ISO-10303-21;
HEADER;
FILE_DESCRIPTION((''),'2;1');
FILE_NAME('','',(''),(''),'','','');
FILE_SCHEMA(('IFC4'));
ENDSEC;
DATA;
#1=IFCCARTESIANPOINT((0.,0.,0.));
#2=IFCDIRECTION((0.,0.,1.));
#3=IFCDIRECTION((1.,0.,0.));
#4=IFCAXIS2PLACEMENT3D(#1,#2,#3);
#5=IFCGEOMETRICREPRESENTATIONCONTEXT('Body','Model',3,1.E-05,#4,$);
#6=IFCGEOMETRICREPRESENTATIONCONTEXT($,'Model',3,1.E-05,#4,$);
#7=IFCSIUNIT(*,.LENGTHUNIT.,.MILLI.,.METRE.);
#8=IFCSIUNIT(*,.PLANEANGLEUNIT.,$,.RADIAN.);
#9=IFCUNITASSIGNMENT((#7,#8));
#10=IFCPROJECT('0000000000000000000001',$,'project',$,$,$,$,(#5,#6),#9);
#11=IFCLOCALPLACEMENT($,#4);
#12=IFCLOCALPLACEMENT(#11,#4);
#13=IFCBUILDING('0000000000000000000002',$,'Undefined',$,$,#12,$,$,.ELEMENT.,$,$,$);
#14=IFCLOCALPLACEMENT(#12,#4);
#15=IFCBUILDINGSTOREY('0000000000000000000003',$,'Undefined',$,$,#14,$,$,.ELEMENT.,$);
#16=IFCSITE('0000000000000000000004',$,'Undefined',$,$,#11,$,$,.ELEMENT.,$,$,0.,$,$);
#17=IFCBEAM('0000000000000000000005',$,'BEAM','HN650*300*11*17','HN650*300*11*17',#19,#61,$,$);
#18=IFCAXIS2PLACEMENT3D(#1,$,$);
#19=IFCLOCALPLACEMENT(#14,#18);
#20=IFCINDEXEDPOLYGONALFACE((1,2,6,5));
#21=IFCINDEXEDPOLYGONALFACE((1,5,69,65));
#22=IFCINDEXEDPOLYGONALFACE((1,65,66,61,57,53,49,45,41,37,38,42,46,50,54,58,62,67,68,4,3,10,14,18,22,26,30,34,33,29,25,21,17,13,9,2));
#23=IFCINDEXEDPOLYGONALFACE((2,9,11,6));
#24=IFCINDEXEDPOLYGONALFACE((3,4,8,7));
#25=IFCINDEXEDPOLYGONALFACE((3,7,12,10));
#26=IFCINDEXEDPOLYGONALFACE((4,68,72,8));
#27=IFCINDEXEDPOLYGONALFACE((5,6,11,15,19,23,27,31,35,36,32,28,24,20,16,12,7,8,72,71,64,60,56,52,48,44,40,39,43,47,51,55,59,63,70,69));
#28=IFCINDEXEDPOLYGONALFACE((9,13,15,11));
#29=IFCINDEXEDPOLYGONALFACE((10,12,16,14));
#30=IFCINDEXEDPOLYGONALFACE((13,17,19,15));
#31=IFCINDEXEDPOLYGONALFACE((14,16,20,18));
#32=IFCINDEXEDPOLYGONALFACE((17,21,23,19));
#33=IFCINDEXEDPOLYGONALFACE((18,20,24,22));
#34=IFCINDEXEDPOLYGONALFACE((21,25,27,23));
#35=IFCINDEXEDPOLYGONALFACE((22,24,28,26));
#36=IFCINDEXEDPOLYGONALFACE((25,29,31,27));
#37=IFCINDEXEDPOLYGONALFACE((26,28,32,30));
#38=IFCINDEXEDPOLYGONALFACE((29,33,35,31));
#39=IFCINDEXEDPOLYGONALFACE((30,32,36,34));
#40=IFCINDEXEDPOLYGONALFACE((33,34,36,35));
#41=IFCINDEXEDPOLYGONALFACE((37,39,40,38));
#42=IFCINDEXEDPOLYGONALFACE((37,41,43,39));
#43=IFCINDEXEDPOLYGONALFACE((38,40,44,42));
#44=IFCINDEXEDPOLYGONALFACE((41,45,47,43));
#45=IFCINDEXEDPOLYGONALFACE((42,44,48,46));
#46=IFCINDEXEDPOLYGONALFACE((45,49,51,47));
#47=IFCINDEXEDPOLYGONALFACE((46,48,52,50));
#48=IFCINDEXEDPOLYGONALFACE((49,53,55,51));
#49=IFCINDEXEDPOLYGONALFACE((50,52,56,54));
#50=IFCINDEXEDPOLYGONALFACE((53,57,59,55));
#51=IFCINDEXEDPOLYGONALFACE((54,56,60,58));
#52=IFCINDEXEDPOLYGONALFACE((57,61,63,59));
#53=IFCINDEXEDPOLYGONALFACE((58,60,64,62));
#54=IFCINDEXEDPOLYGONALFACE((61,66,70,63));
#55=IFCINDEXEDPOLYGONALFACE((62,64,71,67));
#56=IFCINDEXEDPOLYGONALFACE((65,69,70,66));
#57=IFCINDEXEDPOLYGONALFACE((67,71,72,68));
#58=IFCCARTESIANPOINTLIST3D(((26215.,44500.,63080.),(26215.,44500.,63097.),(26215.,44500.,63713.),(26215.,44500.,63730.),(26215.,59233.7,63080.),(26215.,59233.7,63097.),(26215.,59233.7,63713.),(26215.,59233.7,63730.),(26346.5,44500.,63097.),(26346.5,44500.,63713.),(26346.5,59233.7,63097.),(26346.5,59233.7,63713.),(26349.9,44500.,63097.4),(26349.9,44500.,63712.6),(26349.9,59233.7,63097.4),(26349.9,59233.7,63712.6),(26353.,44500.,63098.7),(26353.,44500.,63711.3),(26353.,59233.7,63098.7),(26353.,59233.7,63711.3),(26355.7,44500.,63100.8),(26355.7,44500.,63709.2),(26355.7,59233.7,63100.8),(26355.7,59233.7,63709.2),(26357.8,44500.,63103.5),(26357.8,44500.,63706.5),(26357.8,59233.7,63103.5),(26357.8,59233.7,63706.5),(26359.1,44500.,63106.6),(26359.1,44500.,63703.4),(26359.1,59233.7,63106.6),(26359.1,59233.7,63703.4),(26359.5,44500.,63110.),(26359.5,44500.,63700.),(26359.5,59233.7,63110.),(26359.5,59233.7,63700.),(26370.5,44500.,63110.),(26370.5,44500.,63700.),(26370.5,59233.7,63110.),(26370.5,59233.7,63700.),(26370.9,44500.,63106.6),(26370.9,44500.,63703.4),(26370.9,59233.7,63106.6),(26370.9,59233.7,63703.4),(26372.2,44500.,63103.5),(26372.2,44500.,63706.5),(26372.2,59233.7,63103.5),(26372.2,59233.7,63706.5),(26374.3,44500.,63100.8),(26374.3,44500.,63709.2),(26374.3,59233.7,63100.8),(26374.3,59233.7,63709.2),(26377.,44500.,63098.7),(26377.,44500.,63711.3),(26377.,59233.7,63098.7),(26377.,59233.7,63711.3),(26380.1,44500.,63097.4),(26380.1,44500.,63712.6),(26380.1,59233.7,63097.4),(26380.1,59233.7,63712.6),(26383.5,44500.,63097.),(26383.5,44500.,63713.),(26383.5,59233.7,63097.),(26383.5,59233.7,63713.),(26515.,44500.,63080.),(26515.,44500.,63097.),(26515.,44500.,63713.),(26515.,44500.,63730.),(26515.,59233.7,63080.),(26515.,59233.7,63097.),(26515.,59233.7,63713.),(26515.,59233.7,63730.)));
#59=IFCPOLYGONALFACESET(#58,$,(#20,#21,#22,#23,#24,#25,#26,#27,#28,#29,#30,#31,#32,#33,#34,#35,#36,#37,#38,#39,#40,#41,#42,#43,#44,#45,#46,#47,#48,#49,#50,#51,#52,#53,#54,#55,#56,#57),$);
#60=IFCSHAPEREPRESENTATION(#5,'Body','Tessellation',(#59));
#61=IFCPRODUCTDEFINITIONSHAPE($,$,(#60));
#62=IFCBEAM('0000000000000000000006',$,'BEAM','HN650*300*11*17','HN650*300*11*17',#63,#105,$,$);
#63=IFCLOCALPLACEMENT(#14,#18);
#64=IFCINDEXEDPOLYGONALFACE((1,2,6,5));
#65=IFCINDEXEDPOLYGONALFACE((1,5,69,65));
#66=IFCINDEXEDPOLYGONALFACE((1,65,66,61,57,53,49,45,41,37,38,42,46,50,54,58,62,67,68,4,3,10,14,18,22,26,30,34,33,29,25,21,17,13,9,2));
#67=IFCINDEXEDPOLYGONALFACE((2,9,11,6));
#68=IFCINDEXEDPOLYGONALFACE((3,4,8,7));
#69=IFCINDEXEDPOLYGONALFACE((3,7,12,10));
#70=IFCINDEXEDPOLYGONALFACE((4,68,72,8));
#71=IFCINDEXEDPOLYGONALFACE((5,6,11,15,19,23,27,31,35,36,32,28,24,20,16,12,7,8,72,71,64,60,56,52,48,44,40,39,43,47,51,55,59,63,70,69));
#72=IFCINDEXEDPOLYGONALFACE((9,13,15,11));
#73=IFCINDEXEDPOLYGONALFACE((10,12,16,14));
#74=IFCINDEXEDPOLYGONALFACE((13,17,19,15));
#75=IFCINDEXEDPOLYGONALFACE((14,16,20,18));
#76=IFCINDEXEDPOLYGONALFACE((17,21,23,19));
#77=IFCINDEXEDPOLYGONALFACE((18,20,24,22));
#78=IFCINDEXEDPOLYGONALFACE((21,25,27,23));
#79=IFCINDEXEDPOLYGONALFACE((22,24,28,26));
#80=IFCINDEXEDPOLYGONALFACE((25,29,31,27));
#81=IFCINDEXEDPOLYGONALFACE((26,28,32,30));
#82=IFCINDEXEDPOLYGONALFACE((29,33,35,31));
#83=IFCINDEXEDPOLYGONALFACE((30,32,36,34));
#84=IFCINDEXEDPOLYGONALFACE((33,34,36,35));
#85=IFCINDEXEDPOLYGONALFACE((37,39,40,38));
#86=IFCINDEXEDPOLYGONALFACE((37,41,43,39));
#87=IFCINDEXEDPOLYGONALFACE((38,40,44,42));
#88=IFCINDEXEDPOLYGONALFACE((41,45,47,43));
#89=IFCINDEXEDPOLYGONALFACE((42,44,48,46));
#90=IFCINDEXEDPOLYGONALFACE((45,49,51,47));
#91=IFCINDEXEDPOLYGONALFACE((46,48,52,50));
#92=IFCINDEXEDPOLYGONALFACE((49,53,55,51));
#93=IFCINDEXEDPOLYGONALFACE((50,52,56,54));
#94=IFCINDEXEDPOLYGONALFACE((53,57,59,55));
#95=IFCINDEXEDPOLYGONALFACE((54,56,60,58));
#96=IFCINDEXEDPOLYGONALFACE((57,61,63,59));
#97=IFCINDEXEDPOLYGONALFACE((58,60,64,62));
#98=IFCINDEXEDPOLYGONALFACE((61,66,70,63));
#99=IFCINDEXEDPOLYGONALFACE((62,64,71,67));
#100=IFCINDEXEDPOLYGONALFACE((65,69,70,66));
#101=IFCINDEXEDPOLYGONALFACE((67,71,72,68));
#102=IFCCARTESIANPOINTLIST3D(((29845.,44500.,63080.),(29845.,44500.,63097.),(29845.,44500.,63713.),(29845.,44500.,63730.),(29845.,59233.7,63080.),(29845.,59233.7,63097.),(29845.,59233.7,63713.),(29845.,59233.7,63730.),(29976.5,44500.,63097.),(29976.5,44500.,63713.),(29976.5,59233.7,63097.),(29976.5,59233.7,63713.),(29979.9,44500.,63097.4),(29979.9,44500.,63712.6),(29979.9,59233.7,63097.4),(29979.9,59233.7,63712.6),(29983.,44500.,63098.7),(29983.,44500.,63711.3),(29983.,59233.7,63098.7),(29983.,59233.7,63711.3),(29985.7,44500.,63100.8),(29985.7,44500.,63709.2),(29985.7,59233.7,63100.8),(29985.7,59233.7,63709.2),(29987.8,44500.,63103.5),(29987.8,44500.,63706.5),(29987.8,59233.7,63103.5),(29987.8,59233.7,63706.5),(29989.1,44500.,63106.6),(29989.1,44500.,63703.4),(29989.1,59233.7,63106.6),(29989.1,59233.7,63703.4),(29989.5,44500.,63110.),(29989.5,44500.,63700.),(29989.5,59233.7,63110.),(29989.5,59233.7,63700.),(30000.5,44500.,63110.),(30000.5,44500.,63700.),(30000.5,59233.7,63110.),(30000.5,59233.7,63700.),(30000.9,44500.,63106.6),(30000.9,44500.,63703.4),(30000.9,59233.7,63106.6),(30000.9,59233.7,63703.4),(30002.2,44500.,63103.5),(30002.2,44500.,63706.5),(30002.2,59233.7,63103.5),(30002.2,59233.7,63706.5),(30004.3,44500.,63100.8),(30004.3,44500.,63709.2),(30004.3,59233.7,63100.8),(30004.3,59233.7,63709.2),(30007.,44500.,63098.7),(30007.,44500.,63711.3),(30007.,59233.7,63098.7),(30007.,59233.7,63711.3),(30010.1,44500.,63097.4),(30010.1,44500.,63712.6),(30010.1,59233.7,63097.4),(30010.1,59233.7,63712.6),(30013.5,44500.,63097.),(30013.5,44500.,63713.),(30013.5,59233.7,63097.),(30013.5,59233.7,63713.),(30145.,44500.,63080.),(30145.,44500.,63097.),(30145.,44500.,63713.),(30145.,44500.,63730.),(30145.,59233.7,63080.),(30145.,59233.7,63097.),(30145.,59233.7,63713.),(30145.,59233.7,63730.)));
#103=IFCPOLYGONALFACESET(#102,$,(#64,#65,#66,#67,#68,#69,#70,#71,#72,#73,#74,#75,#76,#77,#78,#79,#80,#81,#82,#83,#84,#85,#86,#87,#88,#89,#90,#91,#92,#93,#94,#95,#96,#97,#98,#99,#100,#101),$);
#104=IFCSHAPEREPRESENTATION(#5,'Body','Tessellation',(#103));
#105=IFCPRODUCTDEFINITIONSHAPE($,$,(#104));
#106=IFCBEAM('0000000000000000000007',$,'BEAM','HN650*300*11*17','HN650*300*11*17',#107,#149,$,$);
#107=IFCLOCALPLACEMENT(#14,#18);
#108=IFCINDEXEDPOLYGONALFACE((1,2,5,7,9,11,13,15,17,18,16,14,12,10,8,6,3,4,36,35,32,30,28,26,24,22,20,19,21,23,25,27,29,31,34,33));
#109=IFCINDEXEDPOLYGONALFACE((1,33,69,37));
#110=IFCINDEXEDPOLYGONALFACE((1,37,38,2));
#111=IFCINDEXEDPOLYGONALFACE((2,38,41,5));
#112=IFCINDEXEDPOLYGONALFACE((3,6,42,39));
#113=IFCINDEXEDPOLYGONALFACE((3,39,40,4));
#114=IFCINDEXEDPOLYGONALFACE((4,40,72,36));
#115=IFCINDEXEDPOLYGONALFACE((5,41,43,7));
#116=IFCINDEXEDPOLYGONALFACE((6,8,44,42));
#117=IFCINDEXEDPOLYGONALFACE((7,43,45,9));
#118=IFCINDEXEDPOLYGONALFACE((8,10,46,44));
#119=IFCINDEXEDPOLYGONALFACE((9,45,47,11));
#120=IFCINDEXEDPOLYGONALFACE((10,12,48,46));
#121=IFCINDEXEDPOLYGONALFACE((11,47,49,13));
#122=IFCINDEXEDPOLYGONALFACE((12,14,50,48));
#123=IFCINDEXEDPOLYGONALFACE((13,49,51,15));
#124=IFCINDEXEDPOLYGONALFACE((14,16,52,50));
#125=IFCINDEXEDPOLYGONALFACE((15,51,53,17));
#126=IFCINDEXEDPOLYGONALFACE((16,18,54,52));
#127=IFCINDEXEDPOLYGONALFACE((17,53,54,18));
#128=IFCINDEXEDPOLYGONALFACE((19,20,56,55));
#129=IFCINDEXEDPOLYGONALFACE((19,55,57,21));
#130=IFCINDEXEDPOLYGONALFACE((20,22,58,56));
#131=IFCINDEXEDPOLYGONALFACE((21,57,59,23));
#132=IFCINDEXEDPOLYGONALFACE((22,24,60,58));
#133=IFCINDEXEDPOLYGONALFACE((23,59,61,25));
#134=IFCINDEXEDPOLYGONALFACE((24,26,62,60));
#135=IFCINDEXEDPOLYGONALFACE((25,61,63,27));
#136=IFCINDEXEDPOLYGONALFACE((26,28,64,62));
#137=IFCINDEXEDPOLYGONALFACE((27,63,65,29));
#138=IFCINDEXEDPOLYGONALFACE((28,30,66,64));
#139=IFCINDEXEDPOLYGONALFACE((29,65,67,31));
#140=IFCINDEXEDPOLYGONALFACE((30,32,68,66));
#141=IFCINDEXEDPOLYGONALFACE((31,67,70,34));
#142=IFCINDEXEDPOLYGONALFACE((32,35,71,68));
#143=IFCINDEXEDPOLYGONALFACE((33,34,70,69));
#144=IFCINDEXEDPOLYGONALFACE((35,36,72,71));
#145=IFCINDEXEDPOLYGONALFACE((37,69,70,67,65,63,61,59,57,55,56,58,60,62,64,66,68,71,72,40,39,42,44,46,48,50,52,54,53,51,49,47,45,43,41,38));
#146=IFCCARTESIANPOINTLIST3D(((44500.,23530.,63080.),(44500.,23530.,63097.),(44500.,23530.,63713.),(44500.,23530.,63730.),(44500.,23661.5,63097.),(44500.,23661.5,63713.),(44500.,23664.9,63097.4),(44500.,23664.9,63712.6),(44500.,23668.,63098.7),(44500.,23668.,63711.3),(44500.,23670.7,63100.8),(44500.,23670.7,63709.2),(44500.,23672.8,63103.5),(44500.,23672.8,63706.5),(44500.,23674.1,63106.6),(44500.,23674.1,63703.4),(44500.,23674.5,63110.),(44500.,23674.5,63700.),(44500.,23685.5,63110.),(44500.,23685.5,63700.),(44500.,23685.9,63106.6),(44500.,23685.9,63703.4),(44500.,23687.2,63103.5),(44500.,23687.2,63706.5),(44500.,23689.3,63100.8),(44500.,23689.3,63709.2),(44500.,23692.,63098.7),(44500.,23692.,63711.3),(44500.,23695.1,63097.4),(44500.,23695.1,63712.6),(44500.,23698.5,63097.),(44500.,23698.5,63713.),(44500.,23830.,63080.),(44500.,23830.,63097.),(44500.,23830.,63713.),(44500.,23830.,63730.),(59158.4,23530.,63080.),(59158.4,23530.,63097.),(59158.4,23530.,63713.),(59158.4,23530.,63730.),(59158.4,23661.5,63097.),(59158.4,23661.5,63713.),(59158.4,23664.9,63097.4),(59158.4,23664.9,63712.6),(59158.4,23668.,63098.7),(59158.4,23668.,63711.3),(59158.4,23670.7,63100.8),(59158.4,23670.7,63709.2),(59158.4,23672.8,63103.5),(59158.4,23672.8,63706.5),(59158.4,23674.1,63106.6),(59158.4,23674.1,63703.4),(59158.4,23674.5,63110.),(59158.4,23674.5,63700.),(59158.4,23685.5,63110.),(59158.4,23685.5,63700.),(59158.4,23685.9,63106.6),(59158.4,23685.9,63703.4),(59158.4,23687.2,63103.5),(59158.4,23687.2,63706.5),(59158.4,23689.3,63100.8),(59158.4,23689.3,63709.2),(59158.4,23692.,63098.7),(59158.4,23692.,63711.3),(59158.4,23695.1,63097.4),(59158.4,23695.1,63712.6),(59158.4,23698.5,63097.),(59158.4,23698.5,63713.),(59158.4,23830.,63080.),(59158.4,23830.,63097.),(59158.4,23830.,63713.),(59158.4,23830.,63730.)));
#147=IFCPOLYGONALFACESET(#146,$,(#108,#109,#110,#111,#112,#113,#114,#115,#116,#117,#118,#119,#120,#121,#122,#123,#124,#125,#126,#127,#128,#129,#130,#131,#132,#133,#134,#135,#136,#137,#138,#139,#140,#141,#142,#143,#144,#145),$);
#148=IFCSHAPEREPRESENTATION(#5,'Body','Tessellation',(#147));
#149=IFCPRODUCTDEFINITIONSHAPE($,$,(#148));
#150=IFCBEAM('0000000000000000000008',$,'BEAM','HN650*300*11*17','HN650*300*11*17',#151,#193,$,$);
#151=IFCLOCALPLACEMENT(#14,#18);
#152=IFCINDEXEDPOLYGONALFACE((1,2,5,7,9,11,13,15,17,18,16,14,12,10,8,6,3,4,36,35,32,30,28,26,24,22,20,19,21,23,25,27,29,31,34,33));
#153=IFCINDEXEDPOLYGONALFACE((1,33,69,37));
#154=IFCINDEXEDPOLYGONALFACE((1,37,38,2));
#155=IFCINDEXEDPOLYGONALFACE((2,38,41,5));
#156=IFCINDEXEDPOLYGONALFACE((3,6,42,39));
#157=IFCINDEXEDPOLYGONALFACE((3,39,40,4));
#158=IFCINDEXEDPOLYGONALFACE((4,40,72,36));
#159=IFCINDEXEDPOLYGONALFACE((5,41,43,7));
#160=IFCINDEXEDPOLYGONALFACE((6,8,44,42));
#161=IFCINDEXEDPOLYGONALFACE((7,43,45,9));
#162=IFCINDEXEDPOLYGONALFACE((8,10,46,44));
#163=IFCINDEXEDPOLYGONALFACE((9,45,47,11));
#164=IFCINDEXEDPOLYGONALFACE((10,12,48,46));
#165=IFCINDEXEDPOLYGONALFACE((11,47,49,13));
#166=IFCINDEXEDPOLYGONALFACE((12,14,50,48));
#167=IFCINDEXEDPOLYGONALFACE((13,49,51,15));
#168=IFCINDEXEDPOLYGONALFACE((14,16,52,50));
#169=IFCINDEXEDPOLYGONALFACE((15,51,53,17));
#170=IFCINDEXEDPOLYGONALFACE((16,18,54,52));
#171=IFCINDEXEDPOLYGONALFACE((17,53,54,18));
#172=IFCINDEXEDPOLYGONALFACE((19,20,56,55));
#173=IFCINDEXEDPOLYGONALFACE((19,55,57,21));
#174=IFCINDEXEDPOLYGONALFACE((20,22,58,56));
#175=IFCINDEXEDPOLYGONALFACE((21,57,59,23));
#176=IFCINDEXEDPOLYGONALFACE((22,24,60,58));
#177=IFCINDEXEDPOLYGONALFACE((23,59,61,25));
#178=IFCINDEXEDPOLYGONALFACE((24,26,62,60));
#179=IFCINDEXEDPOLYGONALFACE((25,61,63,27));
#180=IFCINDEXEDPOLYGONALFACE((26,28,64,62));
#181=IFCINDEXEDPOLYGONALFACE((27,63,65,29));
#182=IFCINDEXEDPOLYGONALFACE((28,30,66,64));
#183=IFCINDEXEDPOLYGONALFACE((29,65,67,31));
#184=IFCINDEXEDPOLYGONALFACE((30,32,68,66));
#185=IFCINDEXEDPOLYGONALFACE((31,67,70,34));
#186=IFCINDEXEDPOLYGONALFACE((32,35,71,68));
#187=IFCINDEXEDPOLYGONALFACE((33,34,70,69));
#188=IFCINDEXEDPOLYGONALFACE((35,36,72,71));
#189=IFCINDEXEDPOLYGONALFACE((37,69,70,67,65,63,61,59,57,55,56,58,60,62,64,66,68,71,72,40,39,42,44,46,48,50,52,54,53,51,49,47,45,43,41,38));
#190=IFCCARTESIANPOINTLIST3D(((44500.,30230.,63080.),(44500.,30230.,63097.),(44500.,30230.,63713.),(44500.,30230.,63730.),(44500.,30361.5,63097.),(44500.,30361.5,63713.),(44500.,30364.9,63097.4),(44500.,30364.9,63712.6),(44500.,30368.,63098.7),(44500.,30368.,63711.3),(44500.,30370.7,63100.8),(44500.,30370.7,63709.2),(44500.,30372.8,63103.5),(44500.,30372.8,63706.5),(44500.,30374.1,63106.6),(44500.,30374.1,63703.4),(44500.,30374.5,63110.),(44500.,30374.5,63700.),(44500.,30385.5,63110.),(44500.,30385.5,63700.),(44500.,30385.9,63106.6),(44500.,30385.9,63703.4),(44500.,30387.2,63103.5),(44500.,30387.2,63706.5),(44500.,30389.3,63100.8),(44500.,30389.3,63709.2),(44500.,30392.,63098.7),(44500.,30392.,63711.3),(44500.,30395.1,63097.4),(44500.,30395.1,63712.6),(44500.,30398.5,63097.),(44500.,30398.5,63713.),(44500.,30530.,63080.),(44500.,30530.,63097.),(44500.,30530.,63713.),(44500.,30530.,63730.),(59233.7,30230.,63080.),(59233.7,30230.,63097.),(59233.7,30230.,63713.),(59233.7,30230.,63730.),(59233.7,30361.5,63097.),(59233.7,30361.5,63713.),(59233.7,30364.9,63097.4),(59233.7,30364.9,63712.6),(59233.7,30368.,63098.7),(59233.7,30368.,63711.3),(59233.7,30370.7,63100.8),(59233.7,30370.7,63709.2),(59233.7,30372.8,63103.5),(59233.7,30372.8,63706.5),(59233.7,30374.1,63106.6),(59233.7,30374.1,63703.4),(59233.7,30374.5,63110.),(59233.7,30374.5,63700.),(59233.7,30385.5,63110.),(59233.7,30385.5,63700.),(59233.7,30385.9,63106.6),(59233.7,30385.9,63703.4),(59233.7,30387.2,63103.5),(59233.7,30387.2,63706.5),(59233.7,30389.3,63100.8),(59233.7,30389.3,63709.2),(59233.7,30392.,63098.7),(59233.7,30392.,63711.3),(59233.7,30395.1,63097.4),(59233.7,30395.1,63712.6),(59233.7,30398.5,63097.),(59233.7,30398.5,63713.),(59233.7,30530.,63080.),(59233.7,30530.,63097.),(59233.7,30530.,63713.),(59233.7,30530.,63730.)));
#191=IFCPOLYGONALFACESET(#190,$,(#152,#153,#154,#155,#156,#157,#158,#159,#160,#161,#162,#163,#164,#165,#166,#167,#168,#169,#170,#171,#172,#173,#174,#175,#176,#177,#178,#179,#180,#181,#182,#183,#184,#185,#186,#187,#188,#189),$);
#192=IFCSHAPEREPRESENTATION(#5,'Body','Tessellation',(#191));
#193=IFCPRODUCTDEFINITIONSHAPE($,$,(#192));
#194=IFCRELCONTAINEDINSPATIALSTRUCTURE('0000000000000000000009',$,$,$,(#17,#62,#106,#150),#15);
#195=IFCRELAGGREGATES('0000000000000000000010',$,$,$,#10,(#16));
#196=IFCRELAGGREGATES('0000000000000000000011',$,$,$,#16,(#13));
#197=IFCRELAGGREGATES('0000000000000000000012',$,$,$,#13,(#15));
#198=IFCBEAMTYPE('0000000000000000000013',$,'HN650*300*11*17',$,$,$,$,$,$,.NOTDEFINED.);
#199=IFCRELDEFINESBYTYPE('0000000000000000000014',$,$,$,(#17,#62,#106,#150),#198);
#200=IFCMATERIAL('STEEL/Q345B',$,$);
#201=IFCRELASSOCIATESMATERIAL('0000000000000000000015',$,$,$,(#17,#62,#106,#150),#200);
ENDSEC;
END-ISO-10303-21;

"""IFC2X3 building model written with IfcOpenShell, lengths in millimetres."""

from ifc_helpers import new_model, si_unit, frame, origin_with_axes, origin_2d_with_axis, place, context, project, spatial, i_section, extrude, material, type_object, element, save


model = new_model("IFC2X3")

# Units and contexts
model_context_1 = context("Model", 3, precision=1e-05, world=origin_with_axes(), identifier="Body")
model_context_2 = context("Model", 3, precision=1e-05, world=origin_with_axes())
ifc_project = project(units=[si_unit("LENGTHUNIT", "METRE", prefix="MILLI"), si_unit("PLANEANGLEUNIT", "RADIAN")], contexts=[model_context_1, model_context_2])

# Site, building, storey
site_placement = place(None, origin_with_axes())
site = spatial("IfcSite", under=ifc_project, at=site_placement, Name="Undefined", CompositionType="ELEMENT", RefElevation=0.0)
building_placement = place(site_placement, origin_with_axes())
building = spatial("IfcBuilding", under=site, at=building_placement, Name="Undefined", CompositionType="ELEMENT")
storey_placement = place(building_placement, origin_with_axes())
storey = spatial("IfcBuildingStorey", under=building, at=storey_placement, Name="Undefined", CompositionType="ELEMENT")

# Beams
ifc_material_1 = material(Name="STEEL/Q345B")
beam_type_1 = type_object("IfcBeamType", Name="HN650*300*11*17", PredefinedType="NOTDEFINED")
for number, where, z_axis, x_axis, name in (
    (1, (26365.0, 44480.0, 63405.0), (0.0, 0.0, 1.0), (0.0, 1.0, 0.0), "BEAM"),
    (2, (29995.0, 44480.0, 63405.0), (0.0, 0.0, 1.0), (0.0, 1.0, 0.0), "BEAM"),
):
    element("IfcBeam", number, at=place(storey_placement, frame(where, z_axis=z_axis, x_axis=x_axis)), inside=storey, type_object=beam_type_1, material=ifc_material_1, Name=name, Description="HN650*300*11*17", ObjectType="HN650*300*11*17", context=model_context_1, shape_type="SweptSolid", body=[
        extrude(i_section(OverallWidth=300.0, OverallDepth=650.0, WebThickness=11.0, FlangeThickness=17.0, FilletRadius=13.0, at=origin_2d_with_axis()), frame((14753.7, 0.0, 0.0), z_axis=(-1.0, 0.0, 0.0), x_axis=(0.0, -1.0, 0.0)), (0.0, 0.0, 1.0), 14733.7),
    ])
beam_1_placement = place(storey_placement, frame((44480.0, 23680.0, 63405.0), z_axis=(0.0, 0.0, 1.0), x_axis=(1.0, 0.0, 0.0)))
element("IfcBeam", 3, at=beam_1_placement, inside=storey, type_object=beam_type_1, material=ifc_material_1, Name="BEAM", Description="HN650*300*11*17", ObjectType="HN650*300*11*17", context=model_context_1, shape_type="SweptSolid", body=[
    extrude(i_section(OverallWidth=300.0, OverallDepth=650.0, WebThickness=11.0, FlangeThickness=17.0, FilletRadius=13.0, at=origin_2d_with_axis()), frame((14678.4, 0.0, 0.0), z_axis=(-1.0, 0.0, 0.0), x_axis=(0.0, -1.0, 0.0)), (0.0, 0.0, 1.0), 14658.4),
])
beam_2_placement = place(storey_placement, frame((44480.0, 30380.0, 63405.0), z_axis=(0.0, 0.0, 1.0), x_axis=(1.0, 0.0, 0.0)))
element("IfcBeam", 4, at=beam_2_placement, inside=storey, type_object=beam_type_1, material=ifc_material_1, Name="BEAM", Description="HN650*300*11*17", ObjectType="HN650*300*11*17", context=model_context_1, shape_type="SweptSolid", body=[
    extrude(i_section(OverallWidth=300.0, OverallDepth=650.0, WebThickness=11.0, FlangeThickness=17.0, FilletRadius=13.0, at=origin_2d_with_axis()), frame((14753.7, 0.0, 0.0), z_axis=(-1.0, 0.0, 0.0), x_axis=(0.0, -1.0, 0.0)), (0.0, 0.0, 1.0), 14733.7),
])

save(model, "model.ifc")
